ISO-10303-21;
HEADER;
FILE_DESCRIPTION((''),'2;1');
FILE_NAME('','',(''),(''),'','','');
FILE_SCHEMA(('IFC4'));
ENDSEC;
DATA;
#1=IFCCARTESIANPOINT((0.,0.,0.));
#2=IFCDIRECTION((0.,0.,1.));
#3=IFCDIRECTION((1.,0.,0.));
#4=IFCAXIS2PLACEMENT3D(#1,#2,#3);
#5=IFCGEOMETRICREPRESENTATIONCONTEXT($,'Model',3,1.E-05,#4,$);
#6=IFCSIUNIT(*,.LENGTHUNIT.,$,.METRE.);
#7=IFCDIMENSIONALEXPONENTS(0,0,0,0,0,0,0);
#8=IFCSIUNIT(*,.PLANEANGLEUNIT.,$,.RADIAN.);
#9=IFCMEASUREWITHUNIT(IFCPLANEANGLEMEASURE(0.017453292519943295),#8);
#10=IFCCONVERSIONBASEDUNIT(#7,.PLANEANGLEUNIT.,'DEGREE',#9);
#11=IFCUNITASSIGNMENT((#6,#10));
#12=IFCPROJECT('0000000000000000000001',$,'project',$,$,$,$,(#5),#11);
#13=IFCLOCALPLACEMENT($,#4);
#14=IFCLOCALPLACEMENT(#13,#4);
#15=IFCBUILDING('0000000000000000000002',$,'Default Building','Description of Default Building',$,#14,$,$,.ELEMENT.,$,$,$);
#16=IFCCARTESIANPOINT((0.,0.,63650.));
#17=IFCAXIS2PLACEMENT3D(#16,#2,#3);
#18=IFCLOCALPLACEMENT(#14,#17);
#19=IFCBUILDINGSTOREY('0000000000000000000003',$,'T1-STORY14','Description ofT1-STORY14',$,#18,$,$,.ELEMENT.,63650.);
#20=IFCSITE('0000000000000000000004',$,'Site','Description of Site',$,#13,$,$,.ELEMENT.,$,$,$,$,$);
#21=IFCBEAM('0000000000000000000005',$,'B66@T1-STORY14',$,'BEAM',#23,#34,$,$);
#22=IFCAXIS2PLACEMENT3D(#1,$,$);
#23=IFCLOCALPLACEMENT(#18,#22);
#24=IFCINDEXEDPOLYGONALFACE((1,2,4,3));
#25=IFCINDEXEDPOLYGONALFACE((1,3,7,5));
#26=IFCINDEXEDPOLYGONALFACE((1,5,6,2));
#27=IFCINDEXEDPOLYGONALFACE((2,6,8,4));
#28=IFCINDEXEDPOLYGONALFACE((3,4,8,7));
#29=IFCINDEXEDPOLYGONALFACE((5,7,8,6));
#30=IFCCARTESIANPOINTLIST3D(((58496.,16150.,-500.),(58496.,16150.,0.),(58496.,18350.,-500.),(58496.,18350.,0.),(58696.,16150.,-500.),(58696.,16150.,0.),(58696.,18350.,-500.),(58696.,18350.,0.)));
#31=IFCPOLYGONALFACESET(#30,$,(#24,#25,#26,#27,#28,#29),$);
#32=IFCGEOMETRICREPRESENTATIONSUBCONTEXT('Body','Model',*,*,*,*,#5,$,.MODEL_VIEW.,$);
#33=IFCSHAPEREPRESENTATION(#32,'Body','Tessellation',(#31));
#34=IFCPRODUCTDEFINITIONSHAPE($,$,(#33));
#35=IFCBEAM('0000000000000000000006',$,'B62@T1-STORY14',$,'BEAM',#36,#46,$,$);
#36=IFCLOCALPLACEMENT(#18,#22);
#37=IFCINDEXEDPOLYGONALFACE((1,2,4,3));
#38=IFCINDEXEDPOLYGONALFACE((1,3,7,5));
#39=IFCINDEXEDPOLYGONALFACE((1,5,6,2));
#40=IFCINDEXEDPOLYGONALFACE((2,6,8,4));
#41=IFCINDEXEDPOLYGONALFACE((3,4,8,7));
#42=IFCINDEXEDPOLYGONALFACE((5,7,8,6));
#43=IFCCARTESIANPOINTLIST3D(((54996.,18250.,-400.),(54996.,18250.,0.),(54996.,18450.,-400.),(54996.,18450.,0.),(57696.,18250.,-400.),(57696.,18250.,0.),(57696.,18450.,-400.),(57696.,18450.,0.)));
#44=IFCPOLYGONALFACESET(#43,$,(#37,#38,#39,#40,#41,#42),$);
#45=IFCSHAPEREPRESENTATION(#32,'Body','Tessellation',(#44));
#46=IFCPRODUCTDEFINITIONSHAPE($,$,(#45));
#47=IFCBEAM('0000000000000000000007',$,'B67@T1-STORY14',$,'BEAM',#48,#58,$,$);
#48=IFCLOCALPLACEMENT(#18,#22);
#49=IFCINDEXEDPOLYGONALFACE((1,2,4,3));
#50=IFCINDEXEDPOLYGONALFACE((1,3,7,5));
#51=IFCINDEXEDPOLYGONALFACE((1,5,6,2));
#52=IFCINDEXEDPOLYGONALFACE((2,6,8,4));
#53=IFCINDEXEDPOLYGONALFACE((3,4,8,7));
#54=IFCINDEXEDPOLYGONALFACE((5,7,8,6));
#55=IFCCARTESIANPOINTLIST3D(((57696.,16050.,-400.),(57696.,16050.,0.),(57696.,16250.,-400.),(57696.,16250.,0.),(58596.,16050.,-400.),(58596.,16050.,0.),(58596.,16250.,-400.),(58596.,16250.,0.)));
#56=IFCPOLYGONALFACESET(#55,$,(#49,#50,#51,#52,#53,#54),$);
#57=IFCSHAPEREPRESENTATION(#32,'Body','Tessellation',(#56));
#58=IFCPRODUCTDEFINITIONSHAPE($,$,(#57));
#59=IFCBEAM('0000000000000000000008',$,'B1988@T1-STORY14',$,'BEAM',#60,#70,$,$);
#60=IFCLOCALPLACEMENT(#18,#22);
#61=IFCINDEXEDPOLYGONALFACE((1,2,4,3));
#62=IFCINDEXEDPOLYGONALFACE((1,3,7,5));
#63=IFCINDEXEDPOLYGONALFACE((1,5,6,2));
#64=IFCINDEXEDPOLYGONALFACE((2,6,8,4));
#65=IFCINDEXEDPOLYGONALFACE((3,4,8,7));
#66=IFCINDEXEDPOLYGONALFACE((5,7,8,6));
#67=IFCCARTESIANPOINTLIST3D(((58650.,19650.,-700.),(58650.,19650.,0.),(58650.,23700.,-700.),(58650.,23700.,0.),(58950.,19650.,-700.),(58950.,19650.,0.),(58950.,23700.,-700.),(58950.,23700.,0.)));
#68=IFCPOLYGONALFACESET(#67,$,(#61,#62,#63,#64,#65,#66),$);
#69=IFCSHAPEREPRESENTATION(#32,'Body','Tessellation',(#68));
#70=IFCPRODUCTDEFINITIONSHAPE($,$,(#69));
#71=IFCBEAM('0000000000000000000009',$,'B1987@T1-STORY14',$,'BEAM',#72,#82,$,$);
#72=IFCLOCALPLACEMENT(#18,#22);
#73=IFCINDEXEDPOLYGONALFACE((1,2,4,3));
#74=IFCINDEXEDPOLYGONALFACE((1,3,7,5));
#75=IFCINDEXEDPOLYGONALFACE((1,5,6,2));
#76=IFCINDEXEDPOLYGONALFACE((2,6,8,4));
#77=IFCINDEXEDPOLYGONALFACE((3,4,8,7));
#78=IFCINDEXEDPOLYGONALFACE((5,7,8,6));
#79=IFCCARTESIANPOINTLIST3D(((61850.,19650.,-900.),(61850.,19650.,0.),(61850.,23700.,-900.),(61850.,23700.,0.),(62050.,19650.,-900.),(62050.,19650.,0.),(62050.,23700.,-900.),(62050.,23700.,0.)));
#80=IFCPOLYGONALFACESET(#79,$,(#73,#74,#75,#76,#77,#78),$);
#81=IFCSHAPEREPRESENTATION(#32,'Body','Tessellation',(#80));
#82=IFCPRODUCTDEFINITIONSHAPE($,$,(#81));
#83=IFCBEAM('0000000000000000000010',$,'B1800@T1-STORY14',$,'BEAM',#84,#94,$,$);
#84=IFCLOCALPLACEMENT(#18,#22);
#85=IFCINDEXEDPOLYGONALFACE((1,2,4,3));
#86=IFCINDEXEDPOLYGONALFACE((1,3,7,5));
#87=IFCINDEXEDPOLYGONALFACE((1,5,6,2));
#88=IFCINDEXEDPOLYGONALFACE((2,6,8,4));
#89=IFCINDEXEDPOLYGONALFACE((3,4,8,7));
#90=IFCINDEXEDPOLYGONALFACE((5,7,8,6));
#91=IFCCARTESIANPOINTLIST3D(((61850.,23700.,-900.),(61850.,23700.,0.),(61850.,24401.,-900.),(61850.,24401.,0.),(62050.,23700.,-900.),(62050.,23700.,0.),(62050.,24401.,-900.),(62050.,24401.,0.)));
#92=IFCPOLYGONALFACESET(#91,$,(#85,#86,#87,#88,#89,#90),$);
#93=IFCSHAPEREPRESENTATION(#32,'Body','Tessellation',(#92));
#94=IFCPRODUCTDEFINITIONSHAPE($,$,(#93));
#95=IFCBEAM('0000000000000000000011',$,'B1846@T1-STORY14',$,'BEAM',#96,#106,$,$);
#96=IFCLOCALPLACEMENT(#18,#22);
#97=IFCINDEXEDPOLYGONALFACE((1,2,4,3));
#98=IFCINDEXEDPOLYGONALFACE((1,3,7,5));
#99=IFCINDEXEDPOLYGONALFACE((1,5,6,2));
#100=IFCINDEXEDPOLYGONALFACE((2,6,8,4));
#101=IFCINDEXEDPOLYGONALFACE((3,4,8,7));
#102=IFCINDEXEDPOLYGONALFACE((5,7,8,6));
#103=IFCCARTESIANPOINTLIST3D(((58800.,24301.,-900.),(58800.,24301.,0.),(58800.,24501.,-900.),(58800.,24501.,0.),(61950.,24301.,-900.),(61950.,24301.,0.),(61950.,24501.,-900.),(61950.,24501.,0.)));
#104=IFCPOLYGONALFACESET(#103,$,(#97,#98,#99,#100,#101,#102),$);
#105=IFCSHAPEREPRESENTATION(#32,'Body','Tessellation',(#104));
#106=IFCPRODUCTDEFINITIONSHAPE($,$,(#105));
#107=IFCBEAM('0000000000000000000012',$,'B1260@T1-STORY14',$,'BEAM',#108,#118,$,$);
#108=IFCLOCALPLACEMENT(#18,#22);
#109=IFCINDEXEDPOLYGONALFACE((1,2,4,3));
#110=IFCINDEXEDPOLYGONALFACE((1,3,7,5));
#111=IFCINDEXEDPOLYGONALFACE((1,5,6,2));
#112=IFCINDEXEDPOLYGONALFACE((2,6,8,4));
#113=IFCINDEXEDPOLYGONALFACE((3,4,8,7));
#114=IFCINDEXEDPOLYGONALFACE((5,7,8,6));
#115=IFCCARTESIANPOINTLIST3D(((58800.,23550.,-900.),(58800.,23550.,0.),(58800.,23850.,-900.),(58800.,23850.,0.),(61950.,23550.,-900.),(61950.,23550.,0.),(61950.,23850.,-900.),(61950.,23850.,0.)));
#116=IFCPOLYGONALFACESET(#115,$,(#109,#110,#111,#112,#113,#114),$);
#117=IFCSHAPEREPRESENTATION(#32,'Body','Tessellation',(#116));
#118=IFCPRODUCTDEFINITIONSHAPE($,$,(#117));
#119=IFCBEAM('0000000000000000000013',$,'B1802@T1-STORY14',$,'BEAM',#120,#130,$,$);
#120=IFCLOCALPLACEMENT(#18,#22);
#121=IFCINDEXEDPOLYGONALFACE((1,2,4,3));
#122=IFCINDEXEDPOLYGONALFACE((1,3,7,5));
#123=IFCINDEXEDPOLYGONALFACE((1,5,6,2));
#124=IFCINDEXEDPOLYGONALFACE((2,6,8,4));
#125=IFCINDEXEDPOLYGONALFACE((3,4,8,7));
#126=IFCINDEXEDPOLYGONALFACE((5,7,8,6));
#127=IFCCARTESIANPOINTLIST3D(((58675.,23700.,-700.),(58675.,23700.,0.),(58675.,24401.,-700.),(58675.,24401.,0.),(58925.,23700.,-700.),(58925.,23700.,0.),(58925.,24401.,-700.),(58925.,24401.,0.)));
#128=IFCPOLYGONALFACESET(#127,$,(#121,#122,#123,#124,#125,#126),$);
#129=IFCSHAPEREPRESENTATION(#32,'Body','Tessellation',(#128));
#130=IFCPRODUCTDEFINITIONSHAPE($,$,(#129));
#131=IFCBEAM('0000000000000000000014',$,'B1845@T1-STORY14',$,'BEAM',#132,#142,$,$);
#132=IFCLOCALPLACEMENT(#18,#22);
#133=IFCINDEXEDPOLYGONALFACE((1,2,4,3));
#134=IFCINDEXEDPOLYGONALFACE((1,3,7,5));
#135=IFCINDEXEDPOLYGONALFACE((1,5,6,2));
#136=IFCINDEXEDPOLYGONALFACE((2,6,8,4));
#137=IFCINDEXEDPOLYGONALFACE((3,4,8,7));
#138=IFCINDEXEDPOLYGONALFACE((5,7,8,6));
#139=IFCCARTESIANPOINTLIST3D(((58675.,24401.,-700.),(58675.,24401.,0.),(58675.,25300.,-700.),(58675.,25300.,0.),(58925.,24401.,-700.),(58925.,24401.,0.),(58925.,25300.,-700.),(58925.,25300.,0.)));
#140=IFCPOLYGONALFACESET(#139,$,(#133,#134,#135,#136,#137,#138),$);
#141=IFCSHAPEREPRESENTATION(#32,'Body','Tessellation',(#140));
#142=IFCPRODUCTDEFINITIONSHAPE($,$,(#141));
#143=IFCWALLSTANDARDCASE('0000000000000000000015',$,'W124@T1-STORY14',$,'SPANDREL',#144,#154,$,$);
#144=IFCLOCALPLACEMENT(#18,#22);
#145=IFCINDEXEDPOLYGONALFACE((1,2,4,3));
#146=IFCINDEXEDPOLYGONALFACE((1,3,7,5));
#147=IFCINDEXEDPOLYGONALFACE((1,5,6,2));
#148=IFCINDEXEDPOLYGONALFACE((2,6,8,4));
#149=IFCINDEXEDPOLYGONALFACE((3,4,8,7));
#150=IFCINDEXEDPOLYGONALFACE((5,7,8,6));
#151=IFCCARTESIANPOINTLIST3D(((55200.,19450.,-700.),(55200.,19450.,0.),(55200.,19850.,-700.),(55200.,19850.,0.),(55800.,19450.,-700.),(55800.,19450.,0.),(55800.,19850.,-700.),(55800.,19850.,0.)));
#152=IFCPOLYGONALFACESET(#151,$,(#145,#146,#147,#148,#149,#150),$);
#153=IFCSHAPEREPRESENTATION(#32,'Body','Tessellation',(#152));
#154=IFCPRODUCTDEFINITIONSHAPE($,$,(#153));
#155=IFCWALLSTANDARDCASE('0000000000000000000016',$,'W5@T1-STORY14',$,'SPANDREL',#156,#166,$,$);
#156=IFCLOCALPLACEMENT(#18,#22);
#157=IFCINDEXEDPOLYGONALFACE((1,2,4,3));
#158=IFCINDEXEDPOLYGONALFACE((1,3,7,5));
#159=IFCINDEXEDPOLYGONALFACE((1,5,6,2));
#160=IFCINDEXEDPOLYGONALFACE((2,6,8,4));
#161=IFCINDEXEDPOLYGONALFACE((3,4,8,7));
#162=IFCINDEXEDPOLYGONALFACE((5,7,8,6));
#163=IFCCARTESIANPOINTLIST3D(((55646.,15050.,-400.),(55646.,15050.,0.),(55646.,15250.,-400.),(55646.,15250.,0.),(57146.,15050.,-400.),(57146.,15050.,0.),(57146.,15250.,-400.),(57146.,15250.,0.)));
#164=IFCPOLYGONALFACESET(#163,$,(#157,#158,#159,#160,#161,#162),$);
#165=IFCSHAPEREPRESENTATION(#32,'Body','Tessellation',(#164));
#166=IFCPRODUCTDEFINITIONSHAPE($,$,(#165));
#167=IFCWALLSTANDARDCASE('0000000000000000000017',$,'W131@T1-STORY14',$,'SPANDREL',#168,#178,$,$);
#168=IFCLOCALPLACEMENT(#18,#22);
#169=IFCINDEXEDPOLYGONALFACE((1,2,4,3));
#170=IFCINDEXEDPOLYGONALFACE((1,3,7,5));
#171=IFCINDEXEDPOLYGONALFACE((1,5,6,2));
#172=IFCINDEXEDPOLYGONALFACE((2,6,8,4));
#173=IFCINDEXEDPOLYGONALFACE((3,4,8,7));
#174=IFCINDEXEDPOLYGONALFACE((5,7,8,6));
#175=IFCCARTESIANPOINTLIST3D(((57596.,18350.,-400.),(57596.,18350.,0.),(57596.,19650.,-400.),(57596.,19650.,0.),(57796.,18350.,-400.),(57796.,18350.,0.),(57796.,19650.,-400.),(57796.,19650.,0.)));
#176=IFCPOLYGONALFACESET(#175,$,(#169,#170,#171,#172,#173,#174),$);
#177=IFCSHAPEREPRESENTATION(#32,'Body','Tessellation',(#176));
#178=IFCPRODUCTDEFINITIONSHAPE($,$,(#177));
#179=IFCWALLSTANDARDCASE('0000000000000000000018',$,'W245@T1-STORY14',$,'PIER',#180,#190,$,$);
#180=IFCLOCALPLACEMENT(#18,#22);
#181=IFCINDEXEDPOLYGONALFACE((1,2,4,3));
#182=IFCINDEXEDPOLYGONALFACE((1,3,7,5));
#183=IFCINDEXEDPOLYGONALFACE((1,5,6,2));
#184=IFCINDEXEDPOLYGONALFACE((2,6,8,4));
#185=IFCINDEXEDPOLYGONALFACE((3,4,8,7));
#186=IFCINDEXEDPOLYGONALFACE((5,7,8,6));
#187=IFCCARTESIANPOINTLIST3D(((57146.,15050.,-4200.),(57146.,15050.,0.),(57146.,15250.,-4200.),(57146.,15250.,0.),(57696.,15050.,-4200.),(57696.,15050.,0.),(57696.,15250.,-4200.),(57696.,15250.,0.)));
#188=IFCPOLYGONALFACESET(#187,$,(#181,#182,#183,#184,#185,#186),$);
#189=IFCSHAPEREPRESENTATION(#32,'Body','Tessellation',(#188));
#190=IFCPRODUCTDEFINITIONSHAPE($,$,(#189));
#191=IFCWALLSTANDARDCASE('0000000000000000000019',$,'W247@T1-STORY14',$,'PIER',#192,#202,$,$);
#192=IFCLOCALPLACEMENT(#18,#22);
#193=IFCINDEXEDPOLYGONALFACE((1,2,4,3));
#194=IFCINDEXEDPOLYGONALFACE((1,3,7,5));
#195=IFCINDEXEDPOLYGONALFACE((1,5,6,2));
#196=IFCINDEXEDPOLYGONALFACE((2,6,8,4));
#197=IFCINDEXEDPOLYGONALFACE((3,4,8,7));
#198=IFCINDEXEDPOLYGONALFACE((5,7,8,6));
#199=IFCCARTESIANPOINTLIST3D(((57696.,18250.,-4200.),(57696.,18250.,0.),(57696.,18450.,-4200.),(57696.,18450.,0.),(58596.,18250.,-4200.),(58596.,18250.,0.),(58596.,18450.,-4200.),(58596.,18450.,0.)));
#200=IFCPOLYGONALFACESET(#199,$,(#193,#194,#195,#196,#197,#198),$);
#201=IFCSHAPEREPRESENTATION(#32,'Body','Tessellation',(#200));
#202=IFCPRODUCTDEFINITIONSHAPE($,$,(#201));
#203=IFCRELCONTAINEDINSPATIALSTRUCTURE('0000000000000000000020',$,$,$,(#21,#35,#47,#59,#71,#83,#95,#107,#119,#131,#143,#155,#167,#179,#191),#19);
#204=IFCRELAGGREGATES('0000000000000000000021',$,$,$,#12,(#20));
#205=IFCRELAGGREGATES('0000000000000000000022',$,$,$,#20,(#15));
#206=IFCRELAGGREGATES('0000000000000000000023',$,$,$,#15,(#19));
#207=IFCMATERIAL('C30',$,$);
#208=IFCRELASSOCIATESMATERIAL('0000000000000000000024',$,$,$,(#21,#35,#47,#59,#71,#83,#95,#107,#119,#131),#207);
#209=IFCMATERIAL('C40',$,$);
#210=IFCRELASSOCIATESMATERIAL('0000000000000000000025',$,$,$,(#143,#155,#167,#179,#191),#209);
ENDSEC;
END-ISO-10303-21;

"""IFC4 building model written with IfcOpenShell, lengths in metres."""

from ifc_helpers import new_model, entity, si_unit, converted_unit, frame, origin_with_axes, place, context, subcontext, project, spatial, indexed_curve, rectangle, outline, extrude, material, element, save


model = new_model("IFC4")

# Units and contexts
model_context = context("Model", 3, precision=1e-05, world=origin_with_axes())
body_context = subcontext(model_context, "Body", "Model", "MODEL_VIEW")
ifc_project = project(units=[si_unit("LENGTHUNIT", "METRE"), converted_unit("PLANEANGLEUNIT", "DEGREE", entity("IfcPlaneAngleMeasure", 0.017453292519943295), si_unit("PLANEANGLEUNIT", "RADIAN"), dimensions=[0, 0, 0, 0, 0, 0, 0])], contexts=[model_context])

# Site, building, storey
site_placement = place(None, origin_with_axes())
site = spatial("IfcSite", under=ifc_project, at=site_placement, Name="Site", Description="Description of Site", CompositionType="ELEMENT")
building_placement = place(site_placement, origin_with_axes())
building = spatial("IfcBuilding", under=site, at=building_placement, Name="Default Building", Description="Description of Default Building", CompositionType="ELEMENT")
storey_placement = place(building_placement, frame((0.0, 0.0, 63650.0), z_axis=(0.0, 0.0, 1.0), x_axis=(1.0, 0.0, 0.0)))
storey = spatial("IfcBuildingStorey", under=building, at=storey_placement, Name="T1-STORY14", Description="Description ofT1-STORY14", CompositionType="ELEMENT", Elevation=63650.0)

# Beams
ifc_material_1 = material(Name="C30")
beam_1_placement = place(storey_placement, frame((58596.0, 16150.0, -250.0), z_axis=(0.0, 1.0, 0.0), x_axis=(-1.0, 0.0, 0.0)))
element("IfcBeam", 1, at=beam_1_placement, inside=storey, material=ifc_material_1, Name="B66@T1-STORY14", ObjectType="BEAM", context=body_context, shape_type="SweptSolid", body=[
    extrude(rectangle(XDim=200.0, YDim=500.0), origin_with_axes(), (0.0, 0.0, 1.0), 2200.0),
])
beam_2_placement = place(storey_placement, frame((54996.0, 18350.0, -200.0), z_axis=(1.0, 0.0, 0.0), x_axis=(0.0, 1.0, 0.0)))
element("IfcBeam", 2, at=beam_2_placement, inside=storey, material=ifc_material_1, Name="B62@T1-STORY14", ObjectType="BEAM", context=body_context, shape_type="SweptSolid", body=[
    extrude(rectangle(XDim=200.0, YDim=400.0), origin_with_axes(), (0.0, 0.0, 1.0), 2700.0),
])
beam_3_placement = place(storey_placement, frame((57696.0, 16150.0, -200.0), z_axis=(1.0, 0.0, 0.0), x_axis=(0.0, 1.0, 0.0)))
element("IfcBeam", 3, at=beam_3_placement, inside=storey, material=ifc_material_1, Name="B67@T1-STORY14", ObjectType="BEAM", context=body_context, shape_type="SweptSolid", body=[
    extrude(rectangle(XDim=200.0, YDim=400.0), origin_with_axes(), (0.0, 0.0, 1.0), 900.0),
])
beam_4_placement = place(storey_placement, frame((58800.0, 19650.0, -350.0), z_axis=(0.0, 1.0, 0.0), x_axis=(-1.0, 0.0, 0.0)))
element("IfcBeam", 4, at=beam_4_placement, inside=storey, material=ifc_material_1, Name="B1988@T1-STORY14", ObjectType="BEAM", context=body_context, shape_type="SweptSolid", body=[
    extrude(rectangle(XDim=300.0, YDim=700.0), origin_with_axes(), (0.0, 0.0, 1.0), 4050.0),
])
beam_5_placement = place(storey_placement, frame((61950.0, 19650.0, -450.0), z_axis=(0.0, 1.0, 0.0), x_axis=(-1.0, 0.0, 0.0)))
element("IfcBeam", 5, at=beam_5_placement, inside=storey, material=ifc_material_1, Name="B1987@T1-STORY14", ObjectType="BEAM", context=body_context, shape_type="SweptSolid", body=[
    extrude(rectangle(XDim=200.0, YDim=900.0), origin_with_axes(), (0.0, 0.0, 1.0), 4050.0),
])
beam_6_placement = place(storey_placement, frame((61950.0, 23700.0, -450.0), z_axis=(0.0, 1.0, 0.0), x_axis=(-1.0, 0.0, 0.0)))
element("IfcBeam", 6, at=beam_6_placement, inside=storey, material=ifc_material_1, Name="B1800@T1-STORY14", ObjectType="BEAM", context=body_context, shape_type="SweptSolid", body=[
    extrude(rectangle(XDim=200.0, YDim=900.0), origin_with_axes(), (0.0, 0.0, 1.0), 701.0),
])
beam_7_placement = place(storey_placement, frame((58800.0, 24401.0, -450.0), z_axis=(1.0, 0.0, 0.0), x_axis=(0.0, 1.0, 0.0)))
element("IfcBeam", 7, at=beam_7_placement, inside=storey, material=ifc_material_1, Name="B1846@T1-STORY14", ObjectType="BEAM", context=body_context, shape_type="SweptSolid", body=[
    extrude(rectangle(XDim=200.0, YDim=900.0), origin_with_axes(), (0.0, 0.0, 1.0), 3150.0),
])
beam_8_placement = place(storey_placement, frame((58800.0, 23700.0, -450.0), z_axis=(1.0, 0.0, 0.0), x_axis=(0.0, 1.0, 0.0)))
element("IfcBeam", 8, at=beam_8_placement, inside=storey, material=ifc_material_1, Name="B1260@T1-STORY14", ObjectType="BEAM", context=body_context, shape_type="SweptSolid", body=[
    extrude(rectangle(XDim=300.0, YDim=900.0), origin_with_axes(), (0.0, 0.0, 1.0), 3150.0),
])
beam_9_placement = place(storey_placement, frame((58800.0, 23700.0, -350.0), z_axis=(0.0, 1.0, 0.0), x_axis=(-1.0, 0.0, 0.0)))
element("IfcBeam", 9, at=beam_9_placement, inside=storey, material=ifc_material_1, Name="B1802@T1-STORY14", ObjectType="BEAM", context=body_context, shape_type="SweptSolid", body=[
    extrude(rectangle(XDim=250.0, YDim=700.0), origin_with_axes(), (0.0, 0.0, 1.0), 701.0),
])
beam_10_placement = place(storey_placement, frame((58800.0, 24401.0, -350.0), z_axis=(0.0, 1.0, 0.0), x_axis=(-1.0, 0.0, 0.0)))
element("IfcBeam", 10, at=beam_10_placement, inside=storey, material=ifc_material_1, Name="B1845@T1-STORY14", ObjectType="BEAM", context=body_context, shape_type="SweptSolid", body=[
    extrude(rectangle(XDim=250.0, YDim=700.0), origin_with_axes(), (0.0, 0.0, 1.0), 899.0),
])
ifc_material_2 = material(Name="C40")

# Walls
wall_1_placement = place(storey_placement, frame((55200.0, 19650.0, -700.0), z_axis=(0.0, 0.0, 1.0), x_axis=(1.0, 0.0, 0.0)))
element("IfcWallStandardCase", 11, at=wall_1_placement, inside=storey, material=ifc_material_2, Name="W124@T1-STORY14", ObjectType="SPANDREL", context=body_context, shape_type="SweptSolid", body=[
    extrude(outline(indexed_curve([(0.0, -200.0), (0.0, 200.0), (600.0, 200.0), (600.0, -200.0), (0.0, -200.0)], self_intersect=False)), origin_with_axes(), (0.0, 0.0, 1.0), 700.0),
])
wall_2_placement = place(storey_placement, frame((55646.0, 15150.0, -400.0), z_axis=(0.0, 0.0, 1.0), x_axis=(1.0, 0.0, 0.0)))
element("IfcWallStandardCase", 12, at=wall_2_placement, inside=storey, material=ifc_material_2, Name="W5@T1-STORY14", ObjectType="SPANDREL", context=body_context, shape_type="SweptSolid", body=[
    extrude(outline(indexed_curve([(0.0, -100.0), (0.0, 100.0), (1500.0, 100.0), (1500.0, -100.0), (0.0, -100.0)], self_intersect=False)), origin_with_axes(), (0.0, 0.0, 1.0), 400.0),
])
wall_3_placement = place(storey_placement, frame((57696.0, 18350.0, -400.0), z_axis=(0.0, 0.0, 1.0), x_axis=(0.0, 1.0, 0.0)))
element("IfcWallStandardCase", 13, at=wall_3_placement, inside=storey, material=ifc_material_2, Name="W131@T1-STORY14", ObjectType="SPANDREL", context=body_context, shape_type="SweptSolid", body=[
    extrude(outline(indexed_curve([(0.0, -100.0), (0.0, 100.0), (1300.0, 100.0), (1300.0, -100.0), (0.0, -100.0)], self_intersect=False)), origin_with_axes(), (0.0, 0.0, 1.0), 400.0),
])
wall_4_placement = place(storey_placement, frame((57146.0, 15150.0, -4200.0), z_axis=(0.0, 0.0, 1.0), x_axis=(1.0, 0.0, 0.0)))
element("IfcWallStandardCase", 14, at=wall_4_placement, inside=storey, material=ifc_material_2, Name="W245@T1-STORY14", ObjectType="PIER", context=body_context, shape_type="SweptSolid", body=[
    extrude(outline(indexed_curve([(0.0, -100.0), (0.0, 100.0), (550.0, 100.0), (550.0, -100.0), (0.0, -100.0)], self_intersect=False)), origin_with_axes(), (0.0, 0.0, 1.0), 4200.0),
])
wall_5_placement = place(storey_placement, frame((57696.0, 18350.0, -4200.0), z_axis=(0.0, 0.0, 1.0), x_axis=(1.0, 0.0, 0.0)))
element("IfcWallStandardCase", 15, at=wall_5_placement, inside=storey, material=ifc_material_2, Name="W247@T1-STORY14", ObjectType="PIER", context=body_context, shape_type="SweptSolid", body=[
    extrude(outline(indexed_curve([(0.0, -100.0), (0.0, 100.0), (900.0, 100.0), (900.0, -100.0), (0.0, -100.0)], self_intersect=False)), origin_with_axes(), (0.0, 0.0, 1.0), 4200.0),
])

save(model, "model.ifc")
